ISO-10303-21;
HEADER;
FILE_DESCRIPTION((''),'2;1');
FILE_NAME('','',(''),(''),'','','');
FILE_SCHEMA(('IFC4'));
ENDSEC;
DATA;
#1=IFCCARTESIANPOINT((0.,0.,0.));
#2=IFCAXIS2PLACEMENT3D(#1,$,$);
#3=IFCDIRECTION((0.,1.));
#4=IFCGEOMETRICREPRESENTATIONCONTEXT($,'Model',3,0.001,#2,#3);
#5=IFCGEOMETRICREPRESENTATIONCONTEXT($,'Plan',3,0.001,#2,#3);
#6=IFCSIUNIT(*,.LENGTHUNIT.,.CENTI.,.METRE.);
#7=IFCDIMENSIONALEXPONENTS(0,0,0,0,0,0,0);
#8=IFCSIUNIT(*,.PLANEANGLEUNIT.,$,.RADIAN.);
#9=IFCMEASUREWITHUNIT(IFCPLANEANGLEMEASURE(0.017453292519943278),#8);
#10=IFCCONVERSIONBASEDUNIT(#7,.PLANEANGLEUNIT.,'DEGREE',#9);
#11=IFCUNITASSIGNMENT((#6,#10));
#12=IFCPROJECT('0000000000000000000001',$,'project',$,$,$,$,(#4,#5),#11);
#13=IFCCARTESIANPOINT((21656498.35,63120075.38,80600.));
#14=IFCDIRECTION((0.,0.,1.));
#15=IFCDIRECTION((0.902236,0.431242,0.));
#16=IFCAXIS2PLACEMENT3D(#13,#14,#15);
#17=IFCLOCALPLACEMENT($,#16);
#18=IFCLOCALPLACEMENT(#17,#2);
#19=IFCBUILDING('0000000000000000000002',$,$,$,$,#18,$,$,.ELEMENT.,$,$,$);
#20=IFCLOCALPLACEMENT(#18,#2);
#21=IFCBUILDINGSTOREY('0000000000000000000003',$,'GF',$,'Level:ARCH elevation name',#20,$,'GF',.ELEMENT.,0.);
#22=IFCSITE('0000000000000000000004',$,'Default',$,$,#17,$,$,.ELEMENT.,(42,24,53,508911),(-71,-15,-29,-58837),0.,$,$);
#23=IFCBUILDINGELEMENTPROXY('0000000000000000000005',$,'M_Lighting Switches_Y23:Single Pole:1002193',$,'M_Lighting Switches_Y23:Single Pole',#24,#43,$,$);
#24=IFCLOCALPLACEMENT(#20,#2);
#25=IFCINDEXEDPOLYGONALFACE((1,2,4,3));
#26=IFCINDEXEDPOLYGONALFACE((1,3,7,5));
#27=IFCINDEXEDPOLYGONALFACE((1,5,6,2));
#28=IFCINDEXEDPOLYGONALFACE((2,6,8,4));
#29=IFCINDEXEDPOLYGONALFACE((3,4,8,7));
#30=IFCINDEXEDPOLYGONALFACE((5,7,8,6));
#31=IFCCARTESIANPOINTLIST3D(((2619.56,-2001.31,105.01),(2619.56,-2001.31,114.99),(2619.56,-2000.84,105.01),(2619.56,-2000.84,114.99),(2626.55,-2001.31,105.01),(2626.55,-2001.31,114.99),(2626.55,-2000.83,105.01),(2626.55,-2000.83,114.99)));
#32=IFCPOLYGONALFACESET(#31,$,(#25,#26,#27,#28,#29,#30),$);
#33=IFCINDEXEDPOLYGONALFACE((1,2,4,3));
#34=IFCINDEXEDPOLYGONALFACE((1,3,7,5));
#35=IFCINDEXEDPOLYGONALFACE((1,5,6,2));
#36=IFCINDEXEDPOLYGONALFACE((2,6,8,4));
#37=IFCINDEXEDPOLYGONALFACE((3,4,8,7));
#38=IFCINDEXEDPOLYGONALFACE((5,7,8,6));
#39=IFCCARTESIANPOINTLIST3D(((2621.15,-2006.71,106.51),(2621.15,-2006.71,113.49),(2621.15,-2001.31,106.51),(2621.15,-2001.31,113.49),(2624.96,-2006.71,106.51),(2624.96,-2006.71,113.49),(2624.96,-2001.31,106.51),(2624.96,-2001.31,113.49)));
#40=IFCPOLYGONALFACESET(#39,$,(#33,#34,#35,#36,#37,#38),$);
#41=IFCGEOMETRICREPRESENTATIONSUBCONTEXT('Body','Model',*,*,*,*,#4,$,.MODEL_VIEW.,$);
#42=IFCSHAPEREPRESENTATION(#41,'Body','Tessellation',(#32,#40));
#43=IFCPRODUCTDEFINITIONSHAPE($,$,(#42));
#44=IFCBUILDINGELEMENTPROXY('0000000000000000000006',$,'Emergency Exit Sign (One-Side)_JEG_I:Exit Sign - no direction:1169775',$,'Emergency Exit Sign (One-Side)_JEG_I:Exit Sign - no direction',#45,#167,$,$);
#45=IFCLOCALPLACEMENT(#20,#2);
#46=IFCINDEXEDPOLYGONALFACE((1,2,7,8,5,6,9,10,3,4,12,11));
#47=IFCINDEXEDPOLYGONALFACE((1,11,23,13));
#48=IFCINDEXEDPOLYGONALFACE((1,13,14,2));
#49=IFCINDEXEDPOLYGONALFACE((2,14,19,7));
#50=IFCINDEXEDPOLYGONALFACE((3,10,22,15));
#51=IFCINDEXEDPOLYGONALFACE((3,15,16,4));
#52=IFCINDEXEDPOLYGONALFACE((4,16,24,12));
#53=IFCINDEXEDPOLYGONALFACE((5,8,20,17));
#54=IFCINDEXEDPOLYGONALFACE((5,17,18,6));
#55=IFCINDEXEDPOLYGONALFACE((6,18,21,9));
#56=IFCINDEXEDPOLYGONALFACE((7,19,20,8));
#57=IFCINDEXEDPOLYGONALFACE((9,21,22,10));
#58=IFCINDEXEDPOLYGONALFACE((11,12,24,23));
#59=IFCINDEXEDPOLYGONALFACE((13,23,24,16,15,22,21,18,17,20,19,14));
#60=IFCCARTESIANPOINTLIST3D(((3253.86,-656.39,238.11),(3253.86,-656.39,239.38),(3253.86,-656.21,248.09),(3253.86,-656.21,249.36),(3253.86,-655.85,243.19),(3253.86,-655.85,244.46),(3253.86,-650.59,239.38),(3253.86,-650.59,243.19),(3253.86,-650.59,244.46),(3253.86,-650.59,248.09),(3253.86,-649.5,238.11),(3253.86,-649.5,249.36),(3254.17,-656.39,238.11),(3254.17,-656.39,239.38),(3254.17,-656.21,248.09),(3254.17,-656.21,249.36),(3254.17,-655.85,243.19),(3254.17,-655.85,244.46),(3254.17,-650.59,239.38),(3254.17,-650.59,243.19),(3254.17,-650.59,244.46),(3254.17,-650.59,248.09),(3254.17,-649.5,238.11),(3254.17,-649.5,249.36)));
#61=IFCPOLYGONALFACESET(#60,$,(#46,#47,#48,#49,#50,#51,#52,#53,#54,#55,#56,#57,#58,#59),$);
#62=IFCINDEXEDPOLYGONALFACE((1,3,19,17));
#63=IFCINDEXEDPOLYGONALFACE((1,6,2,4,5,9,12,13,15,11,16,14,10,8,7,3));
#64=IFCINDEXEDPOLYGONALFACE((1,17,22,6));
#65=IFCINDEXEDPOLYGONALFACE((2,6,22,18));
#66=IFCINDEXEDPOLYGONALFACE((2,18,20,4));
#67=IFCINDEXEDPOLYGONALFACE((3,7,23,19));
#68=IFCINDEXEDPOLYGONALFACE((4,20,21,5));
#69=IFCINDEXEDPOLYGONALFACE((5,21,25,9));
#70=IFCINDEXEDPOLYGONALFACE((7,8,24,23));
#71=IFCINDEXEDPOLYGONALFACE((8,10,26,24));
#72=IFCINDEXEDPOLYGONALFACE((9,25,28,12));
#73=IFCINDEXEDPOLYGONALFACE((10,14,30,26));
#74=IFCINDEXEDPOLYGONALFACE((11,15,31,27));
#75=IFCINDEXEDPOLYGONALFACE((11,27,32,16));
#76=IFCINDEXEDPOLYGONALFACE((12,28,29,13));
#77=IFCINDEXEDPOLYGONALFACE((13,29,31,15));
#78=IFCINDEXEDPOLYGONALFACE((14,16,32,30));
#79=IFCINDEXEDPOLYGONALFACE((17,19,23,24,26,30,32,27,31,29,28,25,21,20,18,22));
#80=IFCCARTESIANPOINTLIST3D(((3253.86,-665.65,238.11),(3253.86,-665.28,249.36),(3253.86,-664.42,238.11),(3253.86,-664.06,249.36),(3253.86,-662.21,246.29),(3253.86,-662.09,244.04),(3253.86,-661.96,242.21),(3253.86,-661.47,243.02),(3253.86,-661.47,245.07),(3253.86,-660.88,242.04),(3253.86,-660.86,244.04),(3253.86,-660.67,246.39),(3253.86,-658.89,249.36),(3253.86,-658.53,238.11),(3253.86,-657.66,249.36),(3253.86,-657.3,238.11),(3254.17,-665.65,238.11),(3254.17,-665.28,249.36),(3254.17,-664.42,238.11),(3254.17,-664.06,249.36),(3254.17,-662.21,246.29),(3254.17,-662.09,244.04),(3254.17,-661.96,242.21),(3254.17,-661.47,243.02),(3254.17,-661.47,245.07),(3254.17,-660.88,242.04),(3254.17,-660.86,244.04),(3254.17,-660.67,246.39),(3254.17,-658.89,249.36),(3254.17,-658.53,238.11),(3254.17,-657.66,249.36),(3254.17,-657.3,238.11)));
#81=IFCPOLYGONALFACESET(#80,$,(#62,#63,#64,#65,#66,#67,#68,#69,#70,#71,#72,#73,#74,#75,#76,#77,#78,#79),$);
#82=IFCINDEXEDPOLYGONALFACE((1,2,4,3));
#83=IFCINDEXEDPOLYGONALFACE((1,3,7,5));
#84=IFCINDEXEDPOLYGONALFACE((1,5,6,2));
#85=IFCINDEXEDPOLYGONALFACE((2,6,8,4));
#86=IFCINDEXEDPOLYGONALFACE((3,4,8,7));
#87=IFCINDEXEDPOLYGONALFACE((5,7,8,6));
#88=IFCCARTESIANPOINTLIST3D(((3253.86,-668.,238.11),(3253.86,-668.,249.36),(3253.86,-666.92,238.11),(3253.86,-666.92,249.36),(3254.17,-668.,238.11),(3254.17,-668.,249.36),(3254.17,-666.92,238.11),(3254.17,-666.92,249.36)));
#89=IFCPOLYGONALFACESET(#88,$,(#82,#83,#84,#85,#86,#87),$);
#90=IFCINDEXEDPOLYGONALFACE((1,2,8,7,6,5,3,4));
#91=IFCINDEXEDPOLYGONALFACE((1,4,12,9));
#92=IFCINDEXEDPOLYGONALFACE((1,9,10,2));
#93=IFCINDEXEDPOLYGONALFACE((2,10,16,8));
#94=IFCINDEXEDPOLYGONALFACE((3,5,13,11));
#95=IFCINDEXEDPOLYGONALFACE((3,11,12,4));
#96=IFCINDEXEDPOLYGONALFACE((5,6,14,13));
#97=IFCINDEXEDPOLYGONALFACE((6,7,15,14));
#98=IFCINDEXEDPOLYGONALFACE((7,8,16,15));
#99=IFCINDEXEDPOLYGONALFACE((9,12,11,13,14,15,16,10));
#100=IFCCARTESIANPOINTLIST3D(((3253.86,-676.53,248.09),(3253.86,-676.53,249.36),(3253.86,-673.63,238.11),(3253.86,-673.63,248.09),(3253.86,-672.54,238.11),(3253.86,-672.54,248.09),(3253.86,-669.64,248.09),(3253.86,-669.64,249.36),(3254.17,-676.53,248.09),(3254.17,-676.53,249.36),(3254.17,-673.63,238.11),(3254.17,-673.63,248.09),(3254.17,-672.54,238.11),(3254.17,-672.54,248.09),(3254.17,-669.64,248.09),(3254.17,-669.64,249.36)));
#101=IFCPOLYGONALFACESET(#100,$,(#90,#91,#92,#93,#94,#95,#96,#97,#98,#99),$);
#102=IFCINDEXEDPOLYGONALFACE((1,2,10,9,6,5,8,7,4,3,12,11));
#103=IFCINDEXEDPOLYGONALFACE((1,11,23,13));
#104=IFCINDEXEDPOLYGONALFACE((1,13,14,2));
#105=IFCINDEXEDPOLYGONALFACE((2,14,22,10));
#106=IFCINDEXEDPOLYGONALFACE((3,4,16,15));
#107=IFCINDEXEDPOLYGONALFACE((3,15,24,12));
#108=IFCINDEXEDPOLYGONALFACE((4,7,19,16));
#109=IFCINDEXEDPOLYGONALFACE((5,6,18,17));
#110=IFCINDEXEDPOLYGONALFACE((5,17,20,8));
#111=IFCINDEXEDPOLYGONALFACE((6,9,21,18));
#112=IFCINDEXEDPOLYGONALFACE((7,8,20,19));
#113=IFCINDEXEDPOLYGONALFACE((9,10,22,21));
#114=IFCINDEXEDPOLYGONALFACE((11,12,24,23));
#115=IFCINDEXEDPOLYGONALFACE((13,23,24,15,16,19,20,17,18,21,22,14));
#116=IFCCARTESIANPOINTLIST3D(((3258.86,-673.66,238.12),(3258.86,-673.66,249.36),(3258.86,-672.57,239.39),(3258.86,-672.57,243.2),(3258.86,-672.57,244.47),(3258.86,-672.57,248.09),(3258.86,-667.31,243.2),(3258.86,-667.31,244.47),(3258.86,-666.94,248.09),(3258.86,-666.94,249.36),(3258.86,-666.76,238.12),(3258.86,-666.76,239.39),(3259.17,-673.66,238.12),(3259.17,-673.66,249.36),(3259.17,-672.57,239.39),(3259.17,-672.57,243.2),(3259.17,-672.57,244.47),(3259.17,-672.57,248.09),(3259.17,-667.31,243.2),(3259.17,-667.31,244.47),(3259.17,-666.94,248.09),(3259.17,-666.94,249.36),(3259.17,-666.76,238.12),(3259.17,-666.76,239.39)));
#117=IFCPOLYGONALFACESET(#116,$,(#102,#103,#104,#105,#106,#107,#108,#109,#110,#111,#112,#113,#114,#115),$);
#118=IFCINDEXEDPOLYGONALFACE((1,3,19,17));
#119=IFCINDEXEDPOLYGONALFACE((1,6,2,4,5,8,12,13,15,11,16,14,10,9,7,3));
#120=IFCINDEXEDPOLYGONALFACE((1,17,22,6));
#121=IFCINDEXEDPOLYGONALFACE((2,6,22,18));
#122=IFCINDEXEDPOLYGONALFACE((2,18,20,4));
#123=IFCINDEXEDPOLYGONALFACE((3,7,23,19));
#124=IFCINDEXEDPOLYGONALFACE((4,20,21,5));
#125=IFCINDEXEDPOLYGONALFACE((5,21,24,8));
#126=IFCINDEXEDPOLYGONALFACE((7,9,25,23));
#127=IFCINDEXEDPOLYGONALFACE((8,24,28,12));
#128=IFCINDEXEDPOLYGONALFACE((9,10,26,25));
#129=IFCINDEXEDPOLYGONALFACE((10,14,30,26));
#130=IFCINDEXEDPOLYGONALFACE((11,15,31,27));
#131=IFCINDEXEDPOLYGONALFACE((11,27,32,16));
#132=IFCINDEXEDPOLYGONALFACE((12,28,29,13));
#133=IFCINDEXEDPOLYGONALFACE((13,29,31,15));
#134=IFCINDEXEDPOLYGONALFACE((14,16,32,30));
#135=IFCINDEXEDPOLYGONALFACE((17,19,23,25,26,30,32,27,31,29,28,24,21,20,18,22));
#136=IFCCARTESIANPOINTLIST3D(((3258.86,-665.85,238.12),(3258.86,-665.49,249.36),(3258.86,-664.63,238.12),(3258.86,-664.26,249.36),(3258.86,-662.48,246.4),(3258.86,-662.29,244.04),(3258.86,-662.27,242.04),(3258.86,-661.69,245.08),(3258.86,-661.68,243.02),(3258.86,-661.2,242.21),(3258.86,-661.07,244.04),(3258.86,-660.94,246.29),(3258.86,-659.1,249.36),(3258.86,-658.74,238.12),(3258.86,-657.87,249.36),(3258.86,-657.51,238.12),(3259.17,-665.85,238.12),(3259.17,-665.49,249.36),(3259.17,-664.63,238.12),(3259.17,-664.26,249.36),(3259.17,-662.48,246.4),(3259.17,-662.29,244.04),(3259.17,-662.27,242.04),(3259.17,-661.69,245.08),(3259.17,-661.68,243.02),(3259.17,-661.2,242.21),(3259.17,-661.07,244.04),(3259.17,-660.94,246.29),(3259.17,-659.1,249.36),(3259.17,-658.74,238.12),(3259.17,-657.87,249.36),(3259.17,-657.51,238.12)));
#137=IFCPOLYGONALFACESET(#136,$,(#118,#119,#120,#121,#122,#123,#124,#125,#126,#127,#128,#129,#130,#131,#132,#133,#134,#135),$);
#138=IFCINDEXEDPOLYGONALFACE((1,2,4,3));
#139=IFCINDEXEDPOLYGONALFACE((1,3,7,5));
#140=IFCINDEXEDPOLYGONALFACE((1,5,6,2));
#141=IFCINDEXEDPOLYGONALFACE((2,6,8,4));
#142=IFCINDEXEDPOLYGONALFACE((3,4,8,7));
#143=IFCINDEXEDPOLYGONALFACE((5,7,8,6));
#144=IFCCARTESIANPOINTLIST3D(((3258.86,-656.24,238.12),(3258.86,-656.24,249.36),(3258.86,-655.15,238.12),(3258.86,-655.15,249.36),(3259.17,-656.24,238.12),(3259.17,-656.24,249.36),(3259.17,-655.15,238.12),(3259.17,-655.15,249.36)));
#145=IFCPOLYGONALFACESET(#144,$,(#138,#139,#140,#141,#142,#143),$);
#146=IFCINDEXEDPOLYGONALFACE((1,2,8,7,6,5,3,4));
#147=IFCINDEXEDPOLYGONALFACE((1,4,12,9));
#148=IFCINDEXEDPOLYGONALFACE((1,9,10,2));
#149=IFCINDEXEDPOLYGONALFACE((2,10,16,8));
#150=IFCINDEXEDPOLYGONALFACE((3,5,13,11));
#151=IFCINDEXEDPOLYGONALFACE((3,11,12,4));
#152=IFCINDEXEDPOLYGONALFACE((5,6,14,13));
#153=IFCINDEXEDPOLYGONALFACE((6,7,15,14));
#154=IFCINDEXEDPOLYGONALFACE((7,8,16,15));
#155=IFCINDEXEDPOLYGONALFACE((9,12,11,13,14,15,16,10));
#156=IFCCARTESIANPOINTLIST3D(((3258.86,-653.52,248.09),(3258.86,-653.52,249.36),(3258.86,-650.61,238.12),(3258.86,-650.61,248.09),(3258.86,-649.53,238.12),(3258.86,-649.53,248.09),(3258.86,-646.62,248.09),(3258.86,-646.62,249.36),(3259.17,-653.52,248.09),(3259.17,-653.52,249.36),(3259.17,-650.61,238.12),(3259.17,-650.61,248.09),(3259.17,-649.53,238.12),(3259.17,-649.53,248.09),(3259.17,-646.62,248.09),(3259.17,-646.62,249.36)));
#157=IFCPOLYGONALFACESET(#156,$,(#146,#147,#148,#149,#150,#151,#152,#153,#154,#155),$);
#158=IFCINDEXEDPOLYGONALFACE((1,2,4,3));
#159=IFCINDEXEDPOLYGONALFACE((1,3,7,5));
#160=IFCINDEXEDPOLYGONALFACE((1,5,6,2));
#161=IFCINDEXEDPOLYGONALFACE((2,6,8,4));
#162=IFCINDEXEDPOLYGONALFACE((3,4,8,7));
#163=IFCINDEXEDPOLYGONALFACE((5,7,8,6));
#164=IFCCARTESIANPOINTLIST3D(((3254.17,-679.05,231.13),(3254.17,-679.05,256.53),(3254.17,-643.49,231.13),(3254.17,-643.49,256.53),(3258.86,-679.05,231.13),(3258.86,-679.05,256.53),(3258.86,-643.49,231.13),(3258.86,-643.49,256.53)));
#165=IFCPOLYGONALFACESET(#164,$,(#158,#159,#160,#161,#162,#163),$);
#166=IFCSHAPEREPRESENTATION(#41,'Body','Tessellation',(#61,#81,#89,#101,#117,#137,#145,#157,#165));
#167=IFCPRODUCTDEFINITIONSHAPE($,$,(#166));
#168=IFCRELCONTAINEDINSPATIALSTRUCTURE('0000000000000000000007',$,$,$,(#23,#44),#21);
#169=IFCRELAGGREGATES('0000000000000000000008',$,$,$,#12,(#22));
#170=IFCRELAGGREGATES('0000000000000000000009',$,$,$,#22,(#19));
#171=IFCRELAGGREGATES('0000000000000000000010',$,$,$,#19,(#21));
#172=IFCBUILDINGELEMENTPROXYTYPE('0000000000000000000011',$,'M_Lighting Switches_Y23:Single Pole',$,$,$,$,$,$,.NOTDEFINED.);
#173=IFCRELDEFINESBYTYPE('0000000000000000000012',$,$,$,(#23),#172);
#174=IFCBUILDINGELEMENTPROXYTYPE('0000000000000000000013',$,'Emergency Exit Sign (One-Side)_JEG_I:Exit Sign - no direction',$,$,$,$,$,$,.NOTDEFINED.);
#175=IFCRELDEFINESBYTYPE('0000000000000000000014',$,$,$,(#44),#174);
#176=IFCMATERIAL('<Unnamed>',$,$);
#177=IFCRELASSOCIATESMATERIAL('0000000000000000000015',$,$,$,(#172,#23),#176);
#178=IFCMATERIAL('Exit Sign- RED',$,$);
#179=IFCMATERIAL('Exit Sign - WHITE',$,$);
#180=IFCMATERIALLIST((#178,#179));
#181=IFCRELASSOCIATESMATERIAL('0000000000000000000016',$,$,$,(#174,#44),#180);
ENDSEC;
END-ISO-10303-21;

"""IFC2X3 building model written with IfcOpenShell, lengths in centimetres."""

from ifc_helpers import new_model, entity, si_unit, converted_unit, direction, frame, frame_2d, origin, origin_2d_with_axis, place, context, subcontext, project, spatial, polyline, rectangle, outline, extrude, source, transform, mapped, material, material_list, type_object, type_shapes, element, save


model = new_model("IFC2X3")

# Units and contexts
model_context = context("Model", 3, precision=0.001, world=origin(), true_north=direction((0.0, 1.0)))
plan_context = context("Plan", 3, precision=0.001, world=origin(), true_north=direction((0.0, 1.0)))
body_context = subcontext(model_context, "Body", "Model", "MODEL_VIEW")
ifc_project = project(units=[si_unit("LENGTHUNIT", "METRE", prefix="CENTI"), converted_unit("PLANEANGLEUNIT", "DEGREE", entity("IfcPlaneAngleMeasure", 0.017453292519943278), si_unit("PLANEANGLEUNIT", "RADIAN"), dimensions=[0, 0, 0, 0, 0, 0, 0])], contexts=[model_context, plan_context])

# Site, building, storey
site_placement = place(None, frame((21656498.35, 63120075.38, 80600.0), z_axis=(0.0, 0.0, 1.0), x_axis=(0.902236, 0.431242, 0.0)))
site = spatial("IfcSite", under=ifc_project, at=site_placement, Name="Default", CompositionType="ELEMENT", RefLatitude=(42, 24, 53, 508911), RefLongitude=(-71, -15, -29, -58837), RefElevation=0.0)
building_placement = place(site_placement, origin())
building = spatial("IfcBuilding", under=site, at=building_placement, CompositionType="ELEMENT")
storey_placement = place(building_placement, origin())
storey = spatial("IfcBuildingStorey", under=building, at=storey_placement, Name="GF", ObjectType="Level:ARCH elevation name", LongName="GF", CompositionType="ELEMENT", Elevation=0.0)

# Shared definitions
ifc_material_1 = material(Name="Exit Sign - WHITE")
ifc_material_2 = material(Name="Exit Sign- RED")

# Building element proxies
ifc_material_3 = material(Name="<Unnamed>")
building_element_proxy_type_1 = type_object("IfcBuildingElementProxyType", Name="M_Lighting Switches_Y23:Single Pole", PredefinedType="NOTDEFINED", material=ifc_material_3)
shared_shape_1 = source(origin(), body_context, "Body", "SweptSolid", [
    extrude(rectangle(XDim=6.99, YDim=9.98, at=frame_2d((0.0, 0.0), x_axis=(1.0, 0.0))), frame((0.0, 0.0, 0.0), z_axis=(0.0, 0.0, 1.0), x_axis=(-1.0, 0.0, 0.0)), (0.0, 0.0, 1.0), 0.48),
    extrude(rectangle(XDim=3.81, YDim=6.98, at=frame_2d((0.0, 0.0), x_axis=(1.0, 0.0))), frame((0.0, 0.0, -5.4), z_axis=(0.0, 0.0, 1.0), x_axis=(-1.0, 0.0, 0.0)), (0.0, 0.0, 1.0), 5.4),
])
type_shapes(building_element_proxy_type_1, [shared_shape_1])
proxy_1_placement = place(storey_placement, frame((2623.05, -2001.31, 110.0), z_axis=(-0.000837, 1.0, 0.0), x_axis=(-1.0, -0.000837, 0.0)))
element("IfcBuildingElementProxy", 1, at=proxy_1_placement, inside=storey, type_object=building_element_proxy_type_1, material=ifc_material_3, Name="M_Lighting Switches_Y23:Single Pole:1002193", ObjectType="M_Lighting Switches_Y23:Single Pole", context=body_context, shape_type="MappedRepresentation", body=[
    mapped(shared_shape_1, transform((0.0, 0.0, 0.0), scale=1.0)),
])
ifc_material_list_1 = material_list([ifc_material_2, ifc_material_1])
building_element_proxy_type_2 = type_object("IfcBuildingElementProxyType", Name="Emergency Exit Sign (One-Side)_JEG_I:Exit Sign - no direction", PredefinedType="NOTDEFINED", material=ifc_material_list_1)
shared_shape_2 = source(origin(), body_context, "Body", "SweptSolid", [
    extrude(outline(polyline([(-5.65, -3.69), (5.59, -3.69), (5.59, 3.02), (4.32, 3.02), (4.32, -2.6), (0.7, -2.6), (0.7, 2.66), (-0.57, 2.66), (-0.57, -2.6), (-4.38, -2.6), (-4.38, 3.21), (-5.65, 3.21), (-5.65, -3.69)])), frame((-8.08, -5.22, 12.64), z_axis=(0.0, 1.0, 0.0), x_axis=(0.0, 0.0, 1.0)), (0.0, 0.0, 1.0), 0.32),
    extrude(outline(polyline([(-7.14, 0.57), (-6.5, -0.49), (-1.93, -0.48), (-0.78, -0.48), (-1.23, -1.32), (-3.47, -5.53), (-2.84, -6.59), (0.41, -0.48), (6.62, -0.48), (5.99, 0.57), (2.4, 0.57), (0.98, 0.58), (1.7, 1.94), (3.32, 5.0), (2.69, 6.05), (-0.22, 0.57), (-7.14, 0.57)])), frame((0.2, -5.22, 12.81), z_axis=(0.0, -1.0, 0.0), x_axis=(0.515099, 0.0, 0.857131)), (0.0, 0.0, -1.0), 0.32),
    extrude(rectangle(XDim=0.32, YDim=1.09, at=frame_2d((0.0, 0.0), x_axis=(1.0, 0.0))), frame((6.19, -5.06, 6.99), z_axis=(0.0, 0.0, 1.0), x_axis=(0.0, 1.0, 0.0)), (0.0, 0.0, 1.0), 11.25),
    extrude(outline(polyline([(-7.8, 0.54), (-7.8, -0.54), (2.18, -0.54), (2.18, -3.45), (3.45, -3.45), (3.45, 3.45), (2.18, 3.45), (2.18, 0.54), (-7.8, 0.54)])), frame((11.82, -5.22, 14.79), z_axis=(0.0, -1.0, 0.0), x_axis=(0.0, 0.0, 1.0)), (0.0, 0.0, -1.0), 0.32),
    extrude(outline(polyline([(-3.69, -5.65), (3.21, -5.65), (3.21, -4.38), (-2.6, -4.38), (-2.6, -0.57), (2.66, -0.57), (2.66, 0.7), (-2.6, 0.7), (-2.6, 4.32), (3.02, 4.32), (3.02, 5.59), (-3.69, 5.59), (-3.69, -5.65)])), frame((8.7, -0.22, 12.65), z_axis=(0.0, 1.0, 0.0), x_axis=(-1.0, 0.0, 0.0)), (0.0, 0.0, 1.0), 0.32),
    extrude(outline(polyline([(-4.16, -5.82), (-2.93, -5.82), (-0.58, -1.9), (0.01, -0.92), (0.5, -1.73), (2.96, -5.82), (4.18, -5.82), (0.62, 0.1), (3.82, 5.42), (2.59, 5.42), (0.75, 2.35), (0.01, 1.14), (-0.79, 2.46), (-2.57, 5.42), (-3.8, 5.42), (-0.6, 0.1), (-4.16, -5.82)])), frame((0.43, -0.22, 12.82), z_axis=(0.0, 1.0, 0.0), x_axis=(-1.0, 0.0, 0.0)), (0.0, 0.0, 1.0), 0.32),
    extrude(rectangle(XDim=0.32, YDim=1.09, at=origin_2d_with_axis()), frame((-5.57, -0.06, 6.99), z_axis=(0.0, 0.0, 1.0), x_axis=(0.0, -1.0, 0.0)), (0.0, 0.0, 1.0), 11.25),
    extrude(outline(polyline([(-0.54, -7.8), (0.54, -7.8), (0.54, 2.18), (3.45, 2.18), (3.45, 3.45), (-3.45, 3.45), (-3.45, 2.18), (-0.54, 2.18), (-0.54, -7.8)])), frame((-11.2, -0.22, 14.79), z_axis=(0.0, 1.0, 0.0), x_axis=(-1.0, 0.0, 0.0)), (0.0, 0.0, 1.0), 0.32),
    extrude(rectangle(XDim=4.68, YDim=35.56, at=origin_2d_with_axis()), frame((0.0, -2.56, 0.01), z_axis=(0.0, 0.0, 1.0), x_axis=(0.0, 1.0, 0.0)), (0.0, 0.0, 1.0), 25.4),
])
type_shapes(building_element_proxy_type_2, [shared_shape_2])
for number, where, z_axis, x_axis, name in (
    (2, (3259.08, -661.27, 231.12), (0.0, 0.0, 1.0), (0.0, -1.0, 0.0), "Emergency Exit Sign (One-Side)_JEG_I:Exit Sign - no direction:1169775"),
):
    element("IfcBuildingElementProxy", number, at=place(storey_placement, frame(where, z_axis=z_axis, x_axis=x_axis)), inside=storey, type_object=building_element_proxy_type_2, material=ifc_material_list_1, Name=name, ObjectType="Emergency Exit Sign (One-Side)_JEG_I:Exit Sign - no direction", context=body_context, shape_type="MappedRepresentation", body=[
        mapped(shared_shape_2, transform((0.0, 0.0, 0.0), scale=1.0)),
    ])

save(model, "model.ifc")
